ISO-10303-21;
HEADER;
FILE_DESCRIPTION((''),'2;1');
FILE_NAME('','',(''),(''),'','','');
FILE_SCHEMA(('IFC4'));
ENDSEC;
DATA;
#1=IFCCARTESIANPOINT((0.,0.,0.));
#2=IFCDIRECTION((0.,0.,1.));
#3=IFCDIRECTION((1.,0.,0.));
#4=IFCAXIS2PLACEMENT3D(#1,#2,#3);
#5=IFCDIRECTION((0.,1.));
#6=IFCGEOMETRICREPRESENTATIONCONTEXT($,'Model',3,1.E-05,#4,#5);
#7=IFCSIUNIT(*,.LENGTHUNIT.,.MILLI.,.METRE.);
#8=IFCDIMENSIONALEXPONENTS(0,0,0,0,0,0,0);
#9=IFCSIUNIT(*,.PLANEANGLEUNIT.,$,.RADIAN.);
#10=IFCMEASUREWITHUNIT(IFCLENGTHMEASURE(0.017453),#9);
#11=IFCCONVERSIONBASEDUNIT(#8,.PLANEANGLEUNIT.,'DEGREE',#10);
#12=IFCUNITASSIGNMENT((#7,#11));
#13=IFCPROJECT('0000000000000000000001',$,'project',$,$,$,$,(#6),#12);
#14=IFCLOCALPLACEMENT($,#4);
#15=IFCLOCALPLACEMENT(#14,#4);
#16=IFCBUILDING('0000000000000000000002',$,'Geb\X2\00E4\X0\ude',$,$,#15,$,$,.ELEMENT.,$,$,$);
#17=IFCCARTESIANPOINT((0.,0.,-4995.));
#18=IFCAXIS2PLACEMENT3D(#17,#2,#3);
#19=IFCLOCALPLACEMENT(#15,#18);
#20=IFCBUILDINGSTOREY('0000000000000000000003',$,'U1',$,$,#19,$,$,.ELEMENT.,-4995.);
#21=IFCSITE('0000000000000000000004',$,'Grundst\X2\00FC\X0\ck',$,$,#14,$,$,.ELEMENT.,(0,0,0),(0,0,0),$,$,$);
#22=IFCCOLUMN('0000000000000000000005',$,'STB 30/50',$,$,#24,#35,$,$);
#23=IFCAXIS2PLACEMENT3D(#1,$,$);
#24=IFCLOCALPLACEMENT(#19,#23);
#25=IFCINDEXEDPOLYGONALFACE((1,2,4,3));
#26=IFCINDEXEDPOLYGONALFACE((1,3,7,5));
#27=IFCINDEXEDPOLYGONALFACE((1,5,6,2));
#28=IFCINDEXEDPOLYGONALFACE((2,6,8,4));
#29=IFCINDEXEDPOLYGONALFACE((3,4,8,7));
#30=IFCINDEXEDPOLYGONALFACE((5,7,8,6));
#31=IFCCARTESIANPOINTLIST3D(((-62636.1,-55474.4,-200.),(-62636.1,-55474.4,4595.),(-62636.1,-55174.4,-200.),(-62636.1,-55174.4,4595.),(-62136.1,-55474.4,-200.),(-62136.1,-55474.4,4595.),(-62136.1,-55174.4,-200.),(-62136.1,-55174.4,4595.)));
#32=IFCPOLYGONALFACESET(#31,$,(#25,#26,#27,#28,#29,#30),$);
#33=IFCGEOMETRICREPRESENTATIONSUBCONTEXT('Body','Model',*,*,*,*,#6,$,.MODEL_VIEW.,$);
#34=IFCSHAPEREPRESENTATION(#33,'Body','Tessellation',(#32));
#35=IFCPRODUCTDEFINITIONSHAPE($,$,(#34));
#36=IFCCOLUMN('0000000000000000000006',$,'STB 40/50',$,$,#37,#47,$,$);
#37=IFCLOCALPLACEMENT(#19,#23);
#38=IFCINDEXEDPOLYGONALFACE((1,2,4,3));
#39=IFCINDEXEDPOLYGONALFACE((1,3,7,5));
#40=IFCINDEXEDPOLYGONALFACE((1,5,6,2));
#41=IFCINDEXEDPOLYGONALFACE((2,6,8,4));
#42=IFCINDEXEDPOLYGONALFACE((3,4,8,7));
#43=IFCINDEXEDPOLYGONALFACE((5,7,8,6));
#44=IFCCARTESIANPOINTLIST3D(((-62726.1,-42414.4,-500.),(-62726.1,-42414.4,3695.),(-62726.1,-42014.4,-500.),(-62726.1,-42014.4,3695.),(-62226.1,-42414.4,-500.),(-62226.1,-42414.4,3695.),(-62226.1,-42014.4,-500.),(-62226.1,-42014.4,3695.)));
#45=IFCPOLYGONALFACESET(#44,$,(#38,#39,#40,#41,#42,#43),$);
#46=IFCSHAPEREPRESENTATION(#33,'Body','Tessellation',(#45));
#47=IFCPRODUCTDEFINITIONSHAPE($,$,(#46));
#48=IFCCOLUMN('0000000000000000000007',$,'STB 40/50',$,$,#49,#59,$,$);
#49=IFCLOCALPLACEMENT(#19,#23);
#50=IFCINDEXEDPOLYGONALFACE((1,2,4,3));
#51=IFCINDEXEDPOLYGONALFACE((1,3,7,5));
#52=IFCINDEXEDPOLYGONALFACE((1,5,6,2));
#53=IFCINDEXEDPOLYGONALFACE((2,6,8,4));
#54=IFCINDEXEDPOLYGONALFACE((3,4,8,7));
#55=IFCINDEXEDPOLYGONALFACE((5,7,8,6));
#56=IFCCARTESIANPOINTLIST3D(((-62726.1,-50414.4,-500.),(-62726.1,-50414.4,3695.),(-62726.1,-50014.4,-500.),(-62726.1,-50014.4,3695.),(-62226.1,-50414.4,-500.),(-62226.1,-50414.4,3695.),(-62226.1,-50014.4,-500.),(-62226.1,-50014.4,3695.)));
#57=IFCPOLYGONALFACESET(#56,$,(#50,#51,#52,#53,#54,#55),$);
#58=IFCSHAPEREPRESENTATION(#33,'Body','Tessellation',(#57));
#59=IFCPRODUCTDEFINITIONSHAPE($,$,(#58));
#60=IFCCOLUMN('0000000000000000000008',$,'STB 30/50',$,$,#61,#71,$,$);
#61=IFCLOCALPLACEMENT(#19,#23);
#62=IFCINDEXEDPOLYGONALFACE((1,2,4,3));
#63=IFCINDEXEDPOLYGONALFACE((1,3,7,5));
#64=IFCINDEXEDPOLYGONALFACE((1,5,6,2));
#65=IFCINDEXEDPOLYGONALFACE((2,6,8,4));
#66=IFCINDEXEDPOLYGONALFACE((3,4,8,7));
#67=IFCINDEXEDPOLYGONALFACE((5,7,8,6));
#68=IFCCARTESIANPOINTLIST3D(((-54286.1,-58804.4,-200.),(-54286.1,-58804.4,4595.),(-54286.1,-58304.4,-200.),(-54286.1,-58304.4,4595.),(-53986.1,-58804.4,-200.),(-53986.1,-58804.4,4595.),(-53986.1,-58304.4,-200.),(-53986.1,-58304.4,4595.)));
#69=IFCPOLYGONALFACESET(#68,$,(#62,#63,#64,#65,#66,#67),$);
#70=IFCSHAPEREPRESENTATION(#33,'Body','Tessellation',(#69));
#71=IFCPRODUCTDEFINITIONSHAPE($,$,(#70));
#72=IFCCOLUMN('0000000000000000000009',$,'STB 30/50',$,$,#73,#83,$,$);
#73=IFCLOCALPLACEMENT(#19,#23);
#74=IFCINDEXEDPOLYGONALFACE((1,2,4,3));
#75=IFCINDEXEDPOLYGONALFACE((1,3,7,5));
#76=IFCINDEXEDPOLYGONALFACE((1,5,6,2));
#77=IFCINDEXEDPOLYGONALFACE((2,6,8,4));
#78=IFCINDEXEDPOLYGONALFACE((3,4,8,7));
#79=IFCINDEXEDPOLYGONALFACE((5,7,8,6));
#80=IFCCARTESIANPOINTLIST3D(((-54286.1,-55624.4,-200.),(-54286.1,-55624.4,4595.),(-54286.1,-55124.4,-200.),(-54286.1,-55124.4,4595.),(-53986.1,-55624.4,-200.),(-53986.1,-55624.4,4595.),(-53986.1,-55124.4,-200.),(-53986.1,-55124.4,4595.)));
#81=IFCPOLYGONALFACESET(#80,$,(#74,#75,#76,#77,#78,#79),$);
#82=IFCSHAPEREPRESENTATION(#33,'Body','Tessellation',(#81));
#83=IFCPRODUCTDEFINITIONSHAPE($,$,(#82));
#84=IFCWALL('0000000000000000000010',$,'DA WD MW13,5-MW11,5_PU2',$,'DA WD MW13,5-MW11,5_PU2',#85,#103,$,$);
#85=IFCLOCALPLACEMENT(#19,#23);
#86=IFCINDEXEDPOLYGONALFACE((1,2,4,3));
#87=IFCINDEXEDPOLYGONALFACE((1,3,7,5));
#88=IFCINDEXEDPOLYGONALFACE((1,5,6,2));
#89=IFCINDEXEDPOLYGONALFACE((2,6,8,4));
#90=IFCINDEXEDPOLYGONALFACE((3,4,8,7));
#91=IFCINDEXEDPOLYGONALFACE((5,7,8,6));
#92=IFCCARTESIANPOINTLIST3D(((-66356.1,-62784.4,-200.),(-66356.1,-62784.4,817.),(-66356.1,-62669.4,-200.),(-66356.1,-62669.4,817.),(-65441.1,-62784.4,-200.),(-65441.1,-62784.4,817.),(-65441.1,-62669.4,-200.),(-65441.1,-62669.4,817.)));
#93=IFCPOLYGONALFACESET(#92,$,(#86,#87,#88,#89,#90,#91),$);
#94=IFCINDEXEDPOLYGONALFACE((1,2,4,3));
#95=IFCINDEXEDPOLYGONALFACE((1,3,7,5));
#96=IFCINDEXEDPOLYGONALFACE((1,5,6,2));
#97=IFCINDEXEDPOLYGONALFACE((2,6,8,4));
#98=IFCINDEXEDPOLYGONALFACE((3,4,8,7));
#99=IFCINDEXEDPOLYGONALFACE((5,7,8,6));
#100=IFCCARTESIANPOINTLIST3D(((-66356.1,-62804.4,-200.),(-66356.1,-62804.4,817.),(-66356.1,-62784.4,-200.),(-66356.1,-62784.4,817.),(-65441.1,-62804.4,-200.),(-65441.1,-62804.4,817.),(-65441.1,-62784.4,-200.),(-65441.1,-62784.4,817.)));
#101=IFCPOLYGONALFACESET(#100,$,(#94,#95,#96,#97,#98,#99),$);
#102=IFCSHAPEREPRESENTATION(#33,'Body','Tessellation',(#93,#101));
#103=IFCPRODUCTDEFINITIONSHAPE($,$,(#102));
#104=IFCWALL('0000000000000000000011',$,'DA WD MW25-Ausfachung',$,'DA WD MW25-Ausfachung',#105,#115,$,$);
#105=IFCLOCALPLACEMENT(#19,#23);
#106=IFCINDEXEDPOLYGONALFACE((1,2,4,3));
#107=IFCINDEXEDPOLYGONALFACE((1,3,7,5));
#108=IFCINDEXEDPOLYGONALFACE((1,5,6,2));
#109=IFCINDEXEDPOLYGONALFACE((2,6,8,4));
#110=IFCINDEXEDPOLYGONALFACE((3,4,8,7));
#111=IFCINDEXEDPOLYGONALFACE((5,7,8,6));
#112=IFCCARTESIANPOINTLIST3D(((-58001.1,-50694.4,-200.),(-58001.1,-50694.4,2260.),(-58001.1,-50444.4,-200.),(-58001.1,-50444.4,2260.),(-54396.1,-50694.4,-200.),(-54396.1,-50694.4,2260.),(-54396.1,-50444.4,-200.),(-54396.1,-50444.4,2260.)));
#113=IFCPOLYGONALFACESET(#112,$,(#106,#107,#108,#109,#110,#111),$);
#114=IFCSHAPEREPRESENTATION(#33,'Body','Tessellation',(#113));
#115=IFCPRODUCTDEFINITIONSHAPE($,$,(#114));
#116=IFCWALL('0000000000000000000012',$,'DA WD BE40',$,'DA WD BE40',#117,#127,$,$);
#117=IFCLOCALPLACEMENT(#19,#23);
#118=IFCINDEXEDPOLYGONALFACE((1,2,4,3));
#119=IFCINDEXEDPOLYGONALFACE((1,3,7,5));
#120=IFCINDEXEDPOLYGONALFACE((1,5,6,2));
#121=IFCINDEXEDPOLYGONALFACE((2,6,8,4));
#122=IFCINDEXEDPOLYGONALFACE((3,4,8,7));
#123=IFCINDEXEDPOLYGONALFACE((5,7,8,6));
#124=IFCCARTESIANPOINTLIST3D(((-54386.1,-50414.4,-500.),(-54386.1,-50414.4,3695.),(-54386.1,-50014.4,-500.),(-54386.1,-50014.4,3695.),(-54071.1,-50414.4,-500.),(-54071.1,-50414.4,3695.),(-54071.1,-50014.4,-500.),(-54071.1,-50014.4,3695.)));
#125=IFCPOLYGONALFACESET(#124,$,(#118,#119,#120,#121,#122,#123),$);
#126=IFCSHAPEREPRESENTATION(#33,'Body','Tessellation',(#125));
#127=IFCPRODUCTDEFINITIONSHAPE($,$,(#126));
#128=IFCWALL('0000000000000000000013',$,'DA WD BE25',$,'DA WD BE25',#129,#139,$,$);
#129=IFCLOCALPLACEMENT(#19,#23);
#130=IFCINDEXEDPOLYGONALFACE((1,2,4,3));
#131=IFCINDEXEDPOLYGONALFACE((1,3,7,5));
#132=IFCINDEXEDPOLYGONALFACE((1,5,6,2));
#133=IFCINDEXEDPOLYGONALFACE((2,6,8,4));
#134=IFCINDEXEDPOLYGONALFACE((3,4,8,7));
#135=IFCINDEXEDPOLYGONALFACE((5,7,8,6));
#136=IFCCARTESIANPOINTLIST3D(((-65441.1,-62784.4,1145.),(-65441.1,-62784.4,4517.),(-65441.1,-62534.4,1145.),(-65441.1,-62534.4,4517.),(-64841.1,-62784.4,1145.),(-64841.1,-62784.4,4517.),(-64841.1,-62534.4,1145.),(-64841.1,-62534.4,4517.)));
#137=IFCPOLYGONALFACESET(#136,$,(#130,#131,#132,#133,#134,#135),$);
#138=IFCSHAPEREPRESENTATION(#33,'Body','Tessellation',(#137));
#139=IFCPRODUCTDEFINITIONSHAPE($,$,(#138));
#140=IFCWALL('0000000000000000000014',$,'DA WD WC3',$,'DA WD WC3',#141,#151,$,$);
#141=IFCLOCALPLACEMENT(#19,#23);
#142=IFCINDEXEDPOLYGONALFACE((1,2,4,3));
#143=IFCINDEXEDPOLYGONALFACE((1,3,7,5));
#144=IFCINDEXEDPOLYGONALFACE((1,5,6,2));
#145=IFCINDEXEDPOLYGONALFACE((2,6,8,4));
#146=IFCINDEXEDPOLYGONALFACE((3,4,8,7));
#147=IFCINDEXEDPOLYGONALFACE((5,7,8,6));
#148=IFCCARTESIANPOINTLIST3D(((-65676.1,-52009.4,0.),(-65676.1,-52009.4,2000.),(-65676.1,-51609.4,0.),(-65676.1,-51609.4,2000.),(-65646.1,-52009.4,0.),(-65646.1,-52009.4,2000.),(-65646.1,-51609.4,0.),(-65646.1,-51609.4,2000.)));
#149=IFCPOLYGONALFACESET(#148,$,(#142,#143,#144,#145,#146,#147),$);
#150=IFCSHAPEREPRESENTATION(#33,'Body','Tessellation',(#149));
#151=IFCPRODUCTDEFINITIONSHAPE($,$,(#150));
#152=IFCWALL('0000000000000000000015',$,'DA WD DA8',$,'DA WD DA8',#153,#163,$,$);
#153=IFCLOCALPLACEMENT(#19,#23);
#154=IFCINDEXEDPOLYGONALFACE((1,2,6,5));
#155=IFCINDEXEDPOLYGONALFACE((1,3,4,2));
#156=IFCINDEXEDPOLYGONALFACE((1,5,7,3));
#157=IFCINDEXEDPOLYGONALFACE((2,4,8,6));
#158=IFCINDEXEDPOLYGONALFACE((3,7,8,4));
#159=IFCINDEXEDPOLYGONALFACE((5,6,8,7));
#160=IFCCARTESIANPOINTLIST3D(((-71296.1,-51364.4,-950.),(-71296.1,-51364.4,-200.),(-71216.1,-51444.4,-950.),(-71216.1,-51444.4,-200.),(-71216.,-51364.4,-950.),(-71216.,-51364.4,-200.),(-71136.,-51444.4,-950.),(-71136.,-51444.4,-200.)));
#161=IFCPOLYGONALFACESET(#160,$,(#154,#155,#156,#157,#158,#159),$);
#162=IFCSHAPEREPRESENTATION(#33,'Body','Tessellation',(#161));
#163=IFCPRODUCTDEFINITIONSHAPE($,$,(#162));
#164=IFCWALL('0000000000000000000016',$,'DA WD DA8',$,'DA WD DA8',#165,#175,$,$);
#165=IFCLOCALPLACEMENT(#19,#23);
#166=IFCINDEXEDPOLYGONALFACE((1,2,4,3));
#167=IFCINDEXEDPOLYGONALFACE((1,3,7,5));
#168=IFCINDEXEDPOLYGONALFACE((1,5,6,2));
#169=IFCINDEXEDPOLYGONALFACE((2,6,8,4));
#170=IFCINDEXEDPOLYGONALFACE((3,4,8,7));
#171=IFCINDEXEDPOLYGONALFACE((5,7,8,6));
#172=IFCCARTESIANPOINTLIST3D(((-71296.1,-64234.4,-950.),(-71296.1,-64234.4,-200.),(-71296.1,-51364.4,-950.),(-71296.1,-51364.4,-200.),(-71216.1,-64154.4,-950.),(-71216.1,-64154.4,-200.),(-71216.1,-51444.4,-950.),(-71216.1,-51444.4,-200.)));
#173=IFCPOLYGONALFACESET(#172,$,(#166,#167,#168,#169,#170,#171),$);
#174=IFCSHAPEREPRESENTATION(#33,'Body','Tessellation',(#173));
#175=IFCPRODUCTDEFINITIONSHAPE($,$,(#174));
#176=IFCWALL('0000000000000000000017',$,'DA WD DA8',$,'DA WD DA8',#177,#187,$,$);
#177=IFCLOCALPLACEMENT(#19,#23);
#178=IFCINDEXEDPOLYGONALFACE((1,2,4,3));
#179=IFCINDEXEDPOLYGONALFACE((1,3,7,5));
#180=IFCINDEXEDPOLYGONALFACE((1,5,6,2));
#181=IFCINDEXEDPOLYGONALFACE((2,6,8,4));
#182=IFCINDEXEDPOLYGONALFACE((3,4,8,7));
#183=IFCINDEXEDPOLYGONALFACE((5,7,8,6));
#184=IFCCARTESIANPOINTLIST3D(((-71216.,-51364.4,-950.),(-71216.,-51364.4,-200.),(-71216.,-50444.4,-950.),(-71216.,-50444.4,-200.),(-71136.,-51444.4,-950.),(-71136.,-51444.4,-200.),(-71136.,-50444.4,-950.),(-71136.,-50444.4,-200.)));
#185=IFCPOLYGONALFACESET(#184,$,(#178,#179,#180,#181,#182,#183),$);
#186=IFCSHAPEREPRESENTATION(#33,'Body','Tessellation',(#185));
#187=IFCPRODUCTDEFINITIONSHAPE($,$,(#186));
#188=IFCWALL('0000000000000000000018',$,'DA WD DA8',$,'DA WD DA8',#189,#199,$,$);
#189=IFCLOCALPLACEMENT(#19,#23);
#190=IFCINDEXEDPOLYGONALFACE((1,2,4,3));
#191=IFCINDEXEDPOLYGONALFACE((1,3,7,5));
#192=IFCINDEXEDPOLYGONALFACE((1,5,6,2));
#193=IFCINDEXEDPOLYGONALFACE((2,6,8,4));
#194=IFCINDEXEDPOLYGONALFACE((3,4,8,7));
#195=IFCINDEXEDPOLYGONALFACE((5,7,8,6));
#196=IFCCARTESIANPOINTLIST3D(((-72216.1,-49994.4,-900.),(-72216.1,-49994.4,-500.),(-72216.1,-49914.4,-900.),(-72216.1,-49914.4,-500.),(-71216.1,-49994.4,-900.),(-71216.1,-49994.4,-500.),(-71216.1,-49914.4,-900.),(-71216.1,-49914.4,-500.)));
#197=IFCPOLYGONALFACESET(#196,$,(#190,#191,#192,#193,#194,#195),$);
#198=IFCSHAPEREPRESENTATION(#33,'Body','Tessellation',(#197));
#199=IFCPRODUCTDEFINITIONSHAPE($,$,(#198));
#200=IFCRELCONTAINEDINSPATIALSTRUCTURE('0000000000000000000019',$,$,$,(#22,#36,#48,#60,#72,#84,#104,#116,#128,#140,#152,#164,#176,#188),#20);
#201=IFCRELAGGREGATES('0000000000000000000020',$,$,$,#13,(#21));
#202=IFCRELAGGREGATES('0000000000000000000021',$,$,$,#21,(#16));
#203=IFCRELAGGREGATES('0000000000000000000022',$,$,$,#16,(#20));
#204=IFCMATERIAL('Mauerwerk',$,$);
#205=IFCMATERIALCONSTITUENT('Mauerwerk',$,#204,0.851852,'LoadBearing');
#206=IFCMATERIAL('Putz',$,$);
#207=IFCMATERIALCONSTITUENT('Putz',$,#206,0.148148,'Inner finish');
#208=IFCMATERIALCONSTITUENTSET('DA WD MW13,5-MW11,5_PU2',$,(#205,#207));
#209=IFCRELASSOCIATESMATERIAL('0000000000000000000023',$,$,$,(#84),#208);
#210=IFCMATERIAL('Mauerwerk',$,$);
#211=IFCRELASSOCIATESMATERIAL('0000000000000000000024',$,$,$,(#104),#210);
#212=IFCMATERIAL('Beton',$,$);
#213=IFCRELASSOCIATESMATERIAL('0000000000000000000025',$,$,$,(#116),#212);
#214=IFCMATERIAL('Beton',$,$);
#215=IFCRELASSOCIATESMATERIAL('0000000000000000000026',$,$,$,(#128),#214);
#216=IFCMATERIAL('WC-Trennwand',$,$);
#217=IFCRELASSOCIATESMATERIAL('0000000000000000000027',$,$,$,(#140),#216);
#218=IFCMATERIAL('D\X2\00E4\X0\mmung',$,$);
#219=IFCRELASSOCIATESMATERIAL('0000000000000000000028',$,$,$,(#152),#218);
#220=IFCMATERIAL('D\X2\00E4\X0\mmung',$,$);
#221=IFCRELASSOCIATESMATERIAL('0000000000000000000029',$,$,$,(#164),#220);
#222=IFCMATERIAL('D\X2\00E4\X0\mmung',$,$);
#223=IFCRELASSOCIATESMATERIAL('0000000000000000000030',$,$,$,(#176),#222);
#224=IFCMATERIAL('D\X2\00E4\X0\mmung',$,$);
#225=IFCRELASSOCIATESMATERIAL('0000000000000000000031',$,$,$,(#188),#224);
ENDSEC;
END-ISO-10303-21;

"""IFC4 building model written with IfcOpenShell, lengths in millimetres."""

from ifc_helpers import new_model, entity, si_unit, converted_unit, direction, frame, origin_with_axes, place, context, subcontext, project, spatial, line, indexed_curve, outline, extrude, material, constituent, constituent_set, element, save


model = new_model("IFC4")

# Units and contexts
model_context = context("Model", 3, precision=1e-05, world=origin_with_axes(), true_north=direction((0.0, 1.0)))
body_context = subcontext(model_context, "Body", "Model", "MODEL_VIEW")
ifc_project = project(units=[si_unit("LENGTHUNIT", "METRE", prefix="MILLI"), converted_unit("PLANEANGLEUNIT", "DEGREE", entity("IfcLengthMeasure", 0.017453), si_unit("PLANEANGLEUNIT", "RADIAN"), dimensions=[0, 0, 0, 0, 0, 0, 0])], contexts=[model_context])

# Site, building, storey
site_placement = place(None, origin_with_axes())
site = spatial("IfcSite", under=ifc_project, at=site_placement, Name="Grundstück", CompositionType="ELEMENT", RefLatitude=(0, 0, 0), RefLongitude=(0, 0, 0))
building_placement = place(site_placement, origin_with_axes())
building = spatial("IfcBuilding", under=site, at=building_placement, Name="Gebäude", CompositionType="ELEMENT")
storey_placement = place(building_placement, frame((0.0, 0.0, -4995.0), z_axis=(0.0, 0.0, 1.0), x_axis=(1.0, 0.0, 0.0)))
storey = spatial("IfcBuildingStorey", under=building, at=storey_placement, Name="U1", CompositionType="ELEMENT", Elevation=-4995.0)

# Columns
column_placement = place(storey_placement, frame((-62386.1, -55324.4, -200.0), z_axis=(0.0, 0.0, 1.0), x_axis=(-1.0, 0.0, 0.0)))
element("IfcColumn", 1, at=column_placement, inside=storey, Name="STB 30/50", context=body_context, shape_type="SweptSolid", body=[
    extrude(outline(indexed_curve([(-250.0, -150.0), (250.0, -150.0), (250.0, 150.0), (-250.0, 150.0)], segments=[line(1, 2), line(2, 3), line(3, 4), line(4, 1)])), origin_with_axes(), (0.0, 0.0, 1.0), 4795.0),
])
for number, where, z_axis, x_axis, name in (
    (2, (-62476.1, -42214.4, -500.0), (0.0, 0.0, 1.0), (1.0, 0.0, 0.0), "STB 40/50"),
    (3, (-62476.1, -50214.4, -500.0), (0.0, 0.0, 1.0), (1.0, 0.0, 0.0), "STB 40/50"),
):
    element("IfcColumn", number, at=place(storey_placement, frame(where, z_axis=z_axis, x_axis=x_axis)), inside=storey, Name=name, context=body_context, shape_type="SweptSolid", body=[
        extrude(outline(indexed_curve([(-250.0, -200.0), (250.0, -200.0), (250.0, 200.0), (-250.0, 200.0)], segments=[line(1, 2), line(2, 3), line(3, 4), line(4, 1)])), origin_with_axes(), (0.0, 0.0, 1.0), 4195.0),
    ])
for number, where, z_axis, x_axis, name in (
    (4, (-54136.1, -58554.4, -200.0), (0.0, 0.0, 1.0), (1.0, 0.0, 0.0), "STB 30/50"),
    (5, (-54136.1, -55374.4, -200.0), (0.0, 0.0, 1.0), (1.0, 0.0, 0.0), "STB 30/50"),
):
    element("IfcColumn", number, at=place(storey_placement, frame(where, z_axis=z_axis, x_axis=x_axis)), inside=storey, Name=name, context=body_context, shape_type="SweptSolid", body=[
        extrude(outline(indexed_curve([(-150.0, -250.0), (150.0, -250.0), (150.0, 250.0), (-150.0, 250.0)], segments=[line(1, 2), line(2, 3), line(3, 4), line(4, 1)])), origin_with_axes(), (0.0, 0.0, 1.0), 4795.0),
    ])

# Walls
ifc_material_1 = material(Name="Mauerwerk")
ifc_constituent_1 = constituent(ifc_material_1, Name="Mauerwerk", Category="LoadBearing", fraction=0.851852)
ifc_material_2 = material(Name="Putz")
ifc_constituent_2 = constituent(ifc_material_2, Name="Putz", Category="Inner finish", fraction=0.148148)
ifc_constituent_set_1 = constituent_set(constituents=[ifc_constituent_1, ifc_constituent_2], Name="DA WD MW13,5-MW11,5_PU2")
wall_1_placement = place(storey_placement, frame((-66356.1, -62736.9, -200.0), z_axis=(0.0, 0.0, 1.0), x_axis=(1.0, 0.0, 0.0)))
element("IfcWall", 6, at=wall_1_placement, inside=storey, material=ifc_constituent_set_1, Name="DA WD MW13,5-MW11,5_PU2", ObjectType="DA WD MW13,5-MW11,5_PU2", context=body_context, shape_type="SweptSolid", body=[
    extrude(outline(indexed_curve([(915.0, 67.5), (915.0, -47.5), (0.0, -47.5), (0.0, 67.5)], segments=[line(1, 2), line(2, 3), line(3, 4), line(4, 1)])), origin_with_axes(), (0.0, 0.0, 1.0), 1017.0),
    extrude(outline(indexed_curve([(915.0, -47.5), (915.0, -67.5), (0.0, -67.5), (0.0, -47.5)], segments=[line(1, 2), line(2, 3), line(3, 4), line(4, 1)])), origin_with_axes(), (0.0, 0.0, 1.0), 1017.0),
])
ifc_material_3 = material(Name="Mauerwerk")
wall_2_placement = place(storey_placement, frame((-58001.1, -50569.4, -200.0), z_axis=(0.0, 0.0, 1.0), x_axis=(1.0, 0.0, 0.0)))
element("IfcWall", 7, at=wall_2_placement, inside=storey, material=ifc_material_3, Name="DA WD MW25-Ausfachung", ObjectType="DA WD MW25-Ausfachung", context=body_context, shape_type="SweptSolid", body=[
    extrude(outline(indexed_curve([(0.0, -125.0), (0.0, 125.0), (3605.0, 125.0), (3605.0, -125.0)], segments=[line(1, 2), line(2, 3), line(3, 4), line(4, 1)])), origin_with_axes(), (0.0, 0.0, 1.0), 2460.0),
])
ifc_material_4 = material(Name="Beton")
wall_3_placement = place(storey_placement, frame((-54386.1, -50214.4, -500.0), z_axis=(0.0, 0.0, 1.0), x_axis=(1.0, 0.0, 0.0)))
element("IfcWall", 8, at=wall_3_placement, inside=storey, material=ifc_material_4, Name="DA WD BE40", ObjectType="DA WD BE40", context=body_context, shape_type="SweptSolid", body=[
    extrude(outline(indexed_curve([(0.0, -200.0), (0.0, 200.0), (315.0, 200.0), (315.0, -200.0)], segments=[line(1, 2), line(2, 3), line(3, 4), line(4, 1)])), origin_with_axes(), (0.0, 0.0, 1.0), 4195.0),
])
ifc_material_5 = material(Name="Beton")
wall_4_placement = place(storey_placement, frame((-65441.1, -62659.4, 1145.0), z_axis=(0.0, 0.0, 1.0), x_axis=(1.0, 0.0, 0.0)))
element("IfcWall", 9, at=wall_4_placement, inside=storey, material=ifc_material_5, Name="DA WD BE25", ObjectType="DA WD BE25", context=body_context, shape_type="SweptSolid", body=[
    extrude(outline(indexed_curve([(0.0, -125.0), (0.0, 125.0), (600.0, 125.0), (600.0, -125.0)], segments=[line(1, 2), line(2, 3), line(3, 4), line(4, 1)])), origin_with_axes(), (0.0, 0.0, 1.0), 3372.0),
])
ifc_material_6 = material(Name="WC-Trennwand")
wall_5_placement = place(storey_placement, frame((-65661.1, -51609.4, 0.0), z_axis=(0.0, 0.0, 1.0), x_axis=(0.0, -1.0, 0.0)))
element("IfcWall", 10, at=wall_5_placement, inside=storey, material=ifc_material_6, Name="DA WD WC3", ObjectType="DA WD WC3", context=body_context, shape_type="SweptSolid", body=[
    extrude(outline(indexed_curve([(0.0, -15.0), (0.0, 15.0), (400.0, 15.0), (400.0, -15.0)], segments=[line(1, 2), line(2, 3), line(3, 4), line(4, 1)])), origin_with_axes(), (0.0, 0.0, 1.0), 2000.0),
])
ifc_material_7 = material(Name="Dämmung")
wall_6_placement = place(storey_placement, frame((-71256.1, -51404.4, -950.0), z_axis=(0.0, 0.0, 1.0), x_axis=(1.0, 0.0, 0.0)))
element("IfcWall", 11, at=wall_6_placement, inside=storey, material=ifc_material_7, Name="DA WD DA8", ObjectType="DA WD DA8", context=body_context, shape_type="SweptSolid", body=[
    extrude(outline(indexed_curve([(40.0, -40.0), (-40.0, 40.0), (40.0, 40.0), (120.0, -40.0)], segments=[line(1, 2), line(2, 3), line(3, 4), line(4, 1)])), origin_with_axes(), (0.0, 0.0, 1.0), 750.0),
])
ifc_material_8 = material(Name="Dämmung")
wall_7_placement = place(storey_placement, frame((-71256.1, -64194.4, -950.0), z_axis=(0.0, 0.0, 1.0), x_axis=(0.0, 1.0, 0.0)))
element("IfcWall", 12, at=wall_7_placement, inside=storey, material=ifc_material_8, Name="DA WD DA8", ObjectType="DA WD DA8", context=body_context, shape_type="SweptSolid", body=[
    extrude(outline(indexed_curve([(40.0, -40.0), (-40.0, 40.0), (12830.0, 40.0), (12750.0, -40.0)], segments=[line(1, 2), line(2, 3), line(3, 4), line(4, 1)])), origin_with_axes(), (0.0, 0.0, 1.0), 750.0),
])
ifc_material_9 = material(Name="Dämmung")
wall_8_placement = place(storey_placement, frame((-71176.0, -50444.4, -950.0), z_axis=(0.0, 0.0, 1.0), x_axis=(0.0, -1.0, 0.0)))
element("IfcWall", 13, at=wall_8_placement, inside=storey, material=ifc_material_9, Name="DA WD DA8", ObjectType="DA WD DA8", context=body_context, shape_type="SweptSolid", body=[
    extrude(outline(indexed_curve([(0.0, -40.0), (0.0, 40.0), (1000.0, 40.0), (920.0, -40.0)], segments=[line(1, 2), line(2, 3), line(3, 4), line(4, 1)])), origin_with_axes(), (0.0, 0.0, 1.0), 750.0),
])
ifc_material_10 = material(Name="Dämmung")
wall_9_placement = place(storey_placement, frame((-71216.1, -49954.4, -900.0), z_axis=(0.0, 0.0, 1.0), x_axis=(-1.0, 0.0, 0.0)))
element("IfcWall", 14, at=wall_9_placement, inside=storey, material=ifc_material_10, Name="DA WD DA8", ObjectType="DA WD DA8", context=body_context, shape_type="SweptSolid", body=[
    extrude(outline(indexed_curve([(0.0, -40.0), (0.0, 40.0), (1000.0, 40.0), (1000.0, -40.0)], segments=[line(1, 2), line(2, 3), line(3, 4), line(4, 1)])), origin_with_axes(), (0.0, 0.0, 1.0), 400.0),
])

save(model, "model.ifc")
